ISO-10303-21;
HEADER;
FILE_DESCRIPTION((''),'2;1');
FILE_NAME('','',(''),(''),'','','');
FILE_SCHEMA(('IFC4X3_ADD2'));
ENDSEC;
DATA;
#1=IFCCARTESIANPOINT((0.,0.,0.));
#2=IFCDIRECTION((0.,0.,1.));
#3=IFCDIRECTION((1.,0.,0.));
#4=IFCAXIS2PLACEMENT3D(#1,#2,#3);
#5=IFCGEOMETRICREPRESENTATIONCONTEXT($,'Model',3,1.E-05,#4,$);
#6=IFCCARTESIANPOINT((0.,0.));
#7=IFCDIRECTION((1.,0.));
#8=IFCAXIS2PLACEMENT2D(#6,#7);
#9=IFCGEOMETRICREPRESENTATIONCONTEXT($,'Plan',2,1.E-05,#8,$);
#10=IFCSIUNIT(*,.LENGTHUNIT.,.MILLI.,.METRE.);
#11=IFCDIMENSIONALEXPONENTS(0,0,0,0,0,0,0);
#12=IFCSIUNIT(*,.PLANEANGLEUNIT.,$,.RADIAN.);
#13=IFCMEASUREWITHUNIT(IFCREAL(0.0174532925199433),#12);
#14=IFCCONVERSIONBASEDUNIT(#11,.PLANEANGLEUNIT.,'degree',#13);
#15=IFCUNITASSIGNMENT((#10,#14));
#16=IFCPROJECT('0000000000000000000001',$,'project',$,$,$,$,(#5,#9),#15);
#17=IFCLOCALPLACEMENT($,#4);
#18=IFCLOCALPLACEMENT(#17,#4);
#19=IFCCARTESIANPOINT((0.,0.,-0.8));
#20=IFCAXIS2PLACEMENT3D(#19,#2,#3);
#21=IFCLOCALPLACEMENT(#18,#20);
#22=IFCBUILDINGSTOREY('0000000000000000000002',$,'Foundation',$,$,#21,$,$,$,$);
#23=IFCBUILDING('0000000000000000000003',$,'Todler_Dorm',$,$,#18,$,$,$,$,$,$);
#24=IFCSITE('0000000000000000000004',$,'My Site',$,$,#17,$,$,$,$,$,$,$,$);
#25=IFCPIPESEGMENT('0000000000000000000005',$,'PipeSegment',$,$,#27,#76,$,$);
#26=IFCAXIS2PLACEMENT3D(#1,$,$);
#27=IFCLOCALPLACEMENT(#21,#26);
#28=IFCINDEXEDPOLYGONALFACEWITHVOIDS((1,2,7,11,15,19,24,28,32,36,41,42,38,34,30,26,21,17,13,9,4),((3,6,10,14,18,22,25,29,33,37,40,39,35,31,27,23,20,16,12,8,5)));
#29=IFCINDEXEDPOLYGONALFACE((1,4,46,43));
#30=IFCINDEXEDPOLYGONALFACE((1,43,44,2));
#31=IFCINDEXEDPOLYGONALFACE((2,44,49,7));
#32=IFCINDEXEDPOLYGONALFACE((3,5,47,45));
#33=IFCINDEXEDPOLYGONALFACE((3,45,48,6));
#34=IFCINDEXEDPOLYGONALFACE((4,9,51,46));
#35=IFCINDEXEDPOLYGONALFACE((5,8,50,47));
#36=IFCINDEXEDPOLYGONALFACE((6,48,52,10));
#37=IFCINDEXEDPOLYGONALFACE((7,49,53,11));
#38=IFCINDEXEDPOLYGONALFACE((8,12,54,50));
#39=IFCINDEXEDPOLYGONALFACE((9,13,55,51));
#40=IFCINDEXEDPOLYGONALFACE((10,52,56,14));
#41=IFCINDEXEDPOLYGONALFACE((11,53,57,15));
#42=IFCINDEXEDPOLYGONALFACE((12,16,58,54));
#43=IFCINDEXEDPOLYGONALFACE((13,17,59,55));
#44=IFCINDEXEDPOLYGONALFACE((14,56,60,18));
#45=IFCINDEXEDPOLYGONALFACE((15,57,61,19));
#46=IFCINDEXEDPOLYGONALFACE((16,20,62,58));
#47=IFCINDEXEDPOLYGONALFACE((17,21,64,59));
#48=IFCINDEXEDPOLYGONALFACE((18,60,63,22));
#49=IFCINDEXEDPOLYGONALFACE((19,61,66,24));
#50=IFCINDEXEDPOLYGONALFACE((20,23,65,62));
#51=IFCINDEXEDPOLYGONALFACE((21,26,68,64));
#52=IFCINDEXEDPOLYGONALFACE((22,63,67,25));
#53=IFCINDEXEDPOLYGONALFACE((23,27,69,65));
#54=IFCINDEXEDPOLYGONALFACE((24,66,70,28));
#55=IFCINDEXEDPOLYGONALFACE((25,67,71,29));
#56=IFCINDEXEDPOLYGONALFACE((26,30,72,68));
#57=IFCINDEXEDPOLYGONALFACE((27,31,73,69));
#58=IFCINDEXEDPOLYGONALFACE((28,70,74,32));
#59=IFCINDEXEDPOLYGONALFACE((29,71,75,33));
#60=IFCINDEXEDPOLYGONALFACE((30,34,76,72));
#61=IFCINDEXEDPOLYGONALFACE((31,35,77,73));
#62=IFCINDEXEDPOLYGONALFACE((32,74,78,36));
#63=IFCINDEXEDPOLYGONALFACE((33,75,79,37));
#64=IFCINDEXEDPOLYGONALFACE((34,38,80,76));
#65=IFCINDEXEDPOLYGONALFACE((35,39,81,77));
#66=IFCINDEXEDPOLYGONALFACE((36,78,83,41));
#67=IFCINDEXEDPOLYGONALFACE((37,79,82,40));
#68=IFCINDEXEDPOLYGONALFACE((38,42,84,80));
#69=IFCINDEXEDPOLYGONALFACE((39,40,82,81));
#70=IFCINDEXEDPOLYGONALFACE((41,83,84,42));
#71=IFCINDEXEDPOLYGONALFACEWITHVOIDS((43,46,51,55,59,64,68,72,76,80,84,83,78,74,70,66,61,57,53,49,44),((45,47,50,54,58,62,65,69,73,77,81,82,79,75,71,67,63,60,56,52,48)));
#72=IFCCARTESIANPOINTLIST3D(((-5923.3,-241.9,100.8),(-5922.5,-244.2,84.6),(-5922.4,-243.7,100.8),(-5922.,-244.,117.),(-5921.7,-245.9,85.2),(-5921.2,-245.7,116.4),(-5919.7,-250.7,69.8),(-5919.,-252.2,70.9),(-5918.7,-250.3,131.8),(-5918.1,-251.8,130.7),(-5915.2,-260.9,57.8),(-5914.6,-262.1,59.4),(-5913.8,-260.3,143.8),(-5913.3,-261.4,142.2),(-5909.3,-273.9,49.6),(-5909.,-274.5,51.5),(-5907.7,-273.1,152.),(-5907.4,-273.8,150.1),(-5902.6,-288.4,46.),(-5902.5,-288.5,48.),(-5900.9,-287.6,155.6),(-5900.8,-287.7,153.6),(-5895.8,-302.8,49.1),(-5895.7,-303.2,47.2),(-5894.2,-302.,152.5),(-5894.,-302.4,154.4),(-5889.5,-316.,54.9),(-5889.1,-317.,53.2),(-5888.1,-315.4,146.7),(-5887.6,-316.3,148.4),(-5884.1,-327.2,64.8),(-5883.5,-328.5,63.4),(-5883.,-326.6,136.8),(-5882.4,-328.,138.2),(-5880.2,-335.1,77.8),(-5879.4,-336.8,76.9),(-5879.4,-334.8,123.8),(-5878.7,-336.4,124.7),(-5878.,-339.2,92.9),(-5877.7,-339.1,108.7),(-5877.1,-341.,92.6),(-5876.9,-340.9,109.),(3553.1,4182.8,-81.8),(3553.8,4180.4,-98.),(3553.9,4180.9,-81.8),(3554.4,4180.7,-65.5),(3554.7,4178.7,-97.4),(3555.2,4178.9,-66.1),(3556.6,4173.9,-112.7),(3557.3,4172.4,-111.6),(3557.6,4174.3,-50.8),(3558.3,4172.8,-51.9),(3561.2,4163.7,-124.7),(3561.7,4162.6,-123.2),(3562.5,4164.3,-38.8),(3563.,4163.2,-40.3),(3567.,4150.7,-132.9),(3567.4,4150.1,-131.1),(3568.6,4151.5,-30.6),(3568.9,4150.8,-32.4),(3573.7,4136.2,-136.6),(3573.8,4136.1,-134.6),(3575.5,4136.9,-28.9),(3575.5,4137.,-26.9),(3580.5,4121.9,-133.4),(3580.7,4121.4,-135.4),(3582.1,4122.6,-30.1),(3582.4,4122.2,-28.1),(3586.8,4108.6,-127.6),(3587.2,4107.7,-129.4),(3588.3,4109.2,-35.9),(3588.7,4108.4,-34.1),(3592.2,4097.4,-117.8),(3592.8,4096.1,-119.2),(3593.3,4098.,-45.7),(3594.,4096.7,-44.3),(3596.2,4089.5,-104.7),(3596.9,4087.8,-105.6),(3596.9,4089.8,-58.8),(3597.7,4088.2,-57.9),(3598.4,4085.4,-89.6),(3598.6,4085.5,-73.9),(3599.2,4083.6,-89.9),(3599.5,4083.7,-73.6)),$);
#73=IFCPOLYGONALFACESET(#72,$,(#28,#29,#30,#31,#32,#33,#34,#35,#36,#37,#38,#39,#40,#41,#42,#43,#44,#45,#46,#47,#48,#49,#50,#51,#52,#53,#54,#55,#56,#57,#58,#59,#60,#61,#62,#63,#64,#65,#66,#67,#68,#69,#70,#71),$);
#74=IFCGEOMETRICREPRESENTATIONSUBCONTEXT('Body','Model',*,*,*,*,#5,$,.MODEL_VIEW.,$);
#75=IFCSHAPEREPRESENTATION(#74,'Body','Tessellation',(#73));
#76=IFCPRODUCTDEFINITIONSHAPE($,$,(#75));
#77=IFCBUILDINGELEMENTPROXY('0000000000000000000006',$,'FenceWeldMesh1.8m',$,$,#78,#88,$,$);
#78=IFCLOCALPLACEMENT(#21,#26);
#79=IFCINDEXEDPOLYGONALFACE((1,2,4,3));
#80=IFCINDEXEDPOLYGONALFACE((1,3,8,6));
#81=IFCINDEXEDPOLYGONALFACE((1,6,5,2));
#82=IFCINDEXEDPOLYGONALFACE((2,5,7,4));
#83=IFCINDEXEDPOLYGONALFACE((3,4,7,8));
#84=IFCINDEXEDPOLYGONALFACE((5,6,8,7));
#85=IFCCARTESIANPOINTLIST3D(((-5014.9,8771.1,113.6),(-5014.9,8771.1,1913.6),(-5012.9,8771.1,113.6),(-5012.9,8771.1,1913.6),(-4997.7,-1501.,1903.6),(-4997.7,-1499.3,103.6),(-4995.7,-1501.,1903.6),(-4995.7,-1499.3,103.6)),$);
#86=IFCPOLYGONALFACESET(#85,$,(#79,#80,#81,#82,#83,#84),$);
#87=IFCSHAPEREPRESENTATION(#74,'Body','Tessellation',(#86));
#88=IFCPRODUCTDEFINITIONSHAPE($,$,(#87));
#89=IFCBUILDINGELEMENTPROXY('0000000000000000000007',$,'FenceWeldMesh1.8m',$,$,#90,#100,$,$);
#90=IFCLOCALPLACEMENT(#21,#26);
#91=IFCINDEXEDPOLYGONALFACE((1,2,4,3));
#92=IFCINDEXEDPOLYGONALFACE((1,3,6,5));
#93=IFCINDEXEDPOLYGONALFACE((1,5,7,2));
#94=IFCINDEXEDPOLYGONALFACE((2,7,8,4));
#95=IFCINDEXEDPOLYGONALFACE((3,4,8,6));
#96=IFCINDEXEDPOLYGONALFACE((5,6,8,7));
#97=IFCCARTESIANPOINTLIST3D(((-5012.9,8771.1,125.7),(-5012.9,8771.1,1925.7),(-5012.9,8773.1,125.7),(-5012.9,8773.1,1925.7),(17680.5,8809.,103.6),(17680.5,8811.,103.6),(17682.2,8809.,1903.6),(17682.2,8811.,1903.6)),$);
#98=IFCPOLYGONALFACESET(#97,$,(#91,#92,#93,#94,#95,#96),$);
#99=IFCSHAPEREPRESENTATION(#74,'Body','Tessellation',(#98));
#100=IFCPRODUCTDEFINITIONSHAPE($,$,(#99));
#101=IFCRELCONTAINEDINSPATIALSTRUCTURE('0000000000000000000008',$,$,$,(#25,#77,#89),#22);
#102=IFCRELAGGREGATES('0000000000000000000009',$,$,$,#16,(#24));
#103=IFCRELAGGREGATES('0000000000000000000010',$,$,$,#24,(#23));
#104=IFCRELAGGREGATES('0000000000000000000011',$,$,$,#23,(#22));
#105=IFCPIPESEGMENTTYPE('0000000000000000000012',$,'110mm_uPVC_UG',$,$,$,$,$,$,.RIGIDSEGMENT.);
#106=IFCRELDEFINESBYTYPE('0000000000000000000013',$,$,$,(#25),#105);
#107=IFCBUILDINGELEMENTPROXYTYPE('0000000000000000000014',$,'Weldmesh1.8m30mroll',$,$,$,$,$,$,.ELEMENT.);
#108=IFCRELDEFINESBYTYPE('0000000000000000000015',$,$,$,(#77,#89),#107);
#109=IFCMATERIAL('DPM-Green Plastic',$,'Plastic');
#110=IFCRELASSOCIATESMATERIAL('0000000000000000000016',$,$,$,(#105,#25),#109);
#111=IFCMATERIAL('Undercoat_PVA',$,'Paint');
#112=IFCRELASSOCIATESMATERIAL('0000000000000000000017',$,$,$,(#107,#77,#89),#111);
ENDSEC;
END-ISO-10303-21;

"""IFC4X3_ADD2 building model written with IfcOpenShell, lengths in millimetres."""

from ifc_helpers import new_model, entity, si_unit, converted_unit, frame, origin_with_axes, origin_2d_with_axis, place, context, subcontext, project, spatial, rectangle, hollow_circle, extrude, clip, halfspace, material, material_profile, profile_set, profile_usage, type_object, element, save


model = new_model("IFC4X3_ADD2")

# Units and contexts
model_context = context("Model", 3, precision=1e-05, world=origin_with_axes())
plan_context = context("Plan", 2, precision=1e-05, world=origin_2d_with_axis())
body_context = subcontext(model_context, "Body", "Model", "MODEL_VIEW")
ifc_project = project(units=[si_unit("LENGTHUNIT", "METRE", prefix="MILLI"), converted_unit("PLANEANGLEUNIT", "degree", entity("IfcReal", 0.0174532925199433), si_unit("PLANEANGLEUNIT", "RADIAN"), dimensions=[0, 0, 0, 0, 0, 0, 0])], contexts=[model_context, plan_context])

# Site, building, storey
site_placement = place(None, origin_with_axes())
site = spatial("IfcSite", under=ifc_project, at=site_placement, Name="My Site")
building_placement = place(site_placement, origin_with_axes())
building = spatial("IfcBuilding", under=site, at=building_placement, Name="Todler_Dorm")
storey_placement = place(building_placement, frame((0.0, 0.0, -0.8), z_axis=(0.0, 0.0, 1.0), x_axis=(1.0, 0.0, 0.0)))
storey = spatial("IfcBuildingStorey", under=building, at=storey_placement, Name="Foundation")

# Shared definitions
ifc_material_1 = material(Name="Undercoat_PVA", Category="Paint")

# Shared definitions
ifc_material_2 = material(Name="DPM-Green Plastic", Category="Plastic")

# Pipe segment
ifc_material_profile_1 = material_profile(ifc_material_2, hollow_circle(Radius=55.0, WallThickness=2.0))
ifc_profile_set_1 = profile_set([ifc_material_profile_1])
ifc_profile_usage_1 = profile_usage(ifc_profile_set_1, cardinal=5)
pipe_segment_type = type_object("IfcPipeSegmentType", Name="110mm_uPVC_UG", PredefinedType="RIGIDSEGMENT", material=ifc_profile_set_1)
pipe_segment_placement = place(storey_placement, frame((-5900.0, -291.7, 100.8), z_axis=(0.90596, 0.423003, -0.017452), x_axis=(-0.423068, 0.906098, 0.0)))
element("IfcPipeSegment", 1, at=pipe_segment_placement, inside=storey, type_object=pipe_segment_type, material=ifc_profile_usage_1, Name="PipeSegment", context=body_context, shape_type="SweptSolid", body=[
    extrude(hollow_circle(Radius=55.0, WallThickness=2.0), origin_with_axes(), (0.0, 0.0, 1.0), 10460.0),
])

# Building element proxies
ifc_material_profile_2 = material_profile(ifc_material_1, rectangle(XDim=1800.0, YDim=2.0))
ifc_profile_set_2 = profile_set([ifc_material_profile_2])
ifc_profile_usage_2 = profile_usage(ifc_profile_set_2, cardinal=5)
building_element_proxy_type = type_object("IfcBuildingElementProxyType", Name="Weldmesh1.8m30mroll", PredefinedType="ELEMENT", material=ifc_profile_set_2)
proxy_1_placement = place(storey_placement, frame((-4996.7, -1500.2, 1003.6), z_axis=(-0.001669, 0.999998, 0.000974), x_axis=(0.0, -0.000974, 1.0)))
element("IfcBuildingElementProxy", 2, at=proxy_1_placement, inside=storey, type_object=building_element_proxy_type, material=ifc_profile_usage_2, Name="FenceWeldMesh1.8m", context=body_context, shape_type="Clipping", body=[
    clip(extrude(rectangle(XDim=1800.0, YDim=2.0), origin_with_axes(), (0.0, 0.0, 1.0), 12071.3), halfspace(frame((-10.0, 22695.2, 10271.3), z_axis=(-0.000973, 0.0, 1.0), x_axis=(-1.0, 0.0, -0.000973)), False)),
])
ifc_profile_usage_3 = profile_usage(ifc_profile_set_2, cardinal=5)
proxy_2_placement = place(storey_placement, frame((17681.4, 8810.0, 1003.6), z_axis=(-0.999998, -0.001669, 0.000974), x_axis=(0.000974, 0.0, 1.0)))
element("IfcBuildingElementProxy", 3, at=proxy_2_placement, inside=storey, type_object=building_element_proxy_type, material=ifc_profile_usage_3, Name="FenceWeldMesh1.8m", context=body_context, shape_type="Clipping", body=[
    clip(extrude(rectangle(XDim=1800.0, YDim=2.0), origin_with_axes(), (0.0, 0.0, 1.0), 24494.3), halfspace(frame((-22.1, -10272.3, 22694.2), z_axis=(-0.000976, 0.0, 1.0), x_axis=(-1.0, 0.0, -0.000976)), False)),
])

save(model, "model.ifc")
